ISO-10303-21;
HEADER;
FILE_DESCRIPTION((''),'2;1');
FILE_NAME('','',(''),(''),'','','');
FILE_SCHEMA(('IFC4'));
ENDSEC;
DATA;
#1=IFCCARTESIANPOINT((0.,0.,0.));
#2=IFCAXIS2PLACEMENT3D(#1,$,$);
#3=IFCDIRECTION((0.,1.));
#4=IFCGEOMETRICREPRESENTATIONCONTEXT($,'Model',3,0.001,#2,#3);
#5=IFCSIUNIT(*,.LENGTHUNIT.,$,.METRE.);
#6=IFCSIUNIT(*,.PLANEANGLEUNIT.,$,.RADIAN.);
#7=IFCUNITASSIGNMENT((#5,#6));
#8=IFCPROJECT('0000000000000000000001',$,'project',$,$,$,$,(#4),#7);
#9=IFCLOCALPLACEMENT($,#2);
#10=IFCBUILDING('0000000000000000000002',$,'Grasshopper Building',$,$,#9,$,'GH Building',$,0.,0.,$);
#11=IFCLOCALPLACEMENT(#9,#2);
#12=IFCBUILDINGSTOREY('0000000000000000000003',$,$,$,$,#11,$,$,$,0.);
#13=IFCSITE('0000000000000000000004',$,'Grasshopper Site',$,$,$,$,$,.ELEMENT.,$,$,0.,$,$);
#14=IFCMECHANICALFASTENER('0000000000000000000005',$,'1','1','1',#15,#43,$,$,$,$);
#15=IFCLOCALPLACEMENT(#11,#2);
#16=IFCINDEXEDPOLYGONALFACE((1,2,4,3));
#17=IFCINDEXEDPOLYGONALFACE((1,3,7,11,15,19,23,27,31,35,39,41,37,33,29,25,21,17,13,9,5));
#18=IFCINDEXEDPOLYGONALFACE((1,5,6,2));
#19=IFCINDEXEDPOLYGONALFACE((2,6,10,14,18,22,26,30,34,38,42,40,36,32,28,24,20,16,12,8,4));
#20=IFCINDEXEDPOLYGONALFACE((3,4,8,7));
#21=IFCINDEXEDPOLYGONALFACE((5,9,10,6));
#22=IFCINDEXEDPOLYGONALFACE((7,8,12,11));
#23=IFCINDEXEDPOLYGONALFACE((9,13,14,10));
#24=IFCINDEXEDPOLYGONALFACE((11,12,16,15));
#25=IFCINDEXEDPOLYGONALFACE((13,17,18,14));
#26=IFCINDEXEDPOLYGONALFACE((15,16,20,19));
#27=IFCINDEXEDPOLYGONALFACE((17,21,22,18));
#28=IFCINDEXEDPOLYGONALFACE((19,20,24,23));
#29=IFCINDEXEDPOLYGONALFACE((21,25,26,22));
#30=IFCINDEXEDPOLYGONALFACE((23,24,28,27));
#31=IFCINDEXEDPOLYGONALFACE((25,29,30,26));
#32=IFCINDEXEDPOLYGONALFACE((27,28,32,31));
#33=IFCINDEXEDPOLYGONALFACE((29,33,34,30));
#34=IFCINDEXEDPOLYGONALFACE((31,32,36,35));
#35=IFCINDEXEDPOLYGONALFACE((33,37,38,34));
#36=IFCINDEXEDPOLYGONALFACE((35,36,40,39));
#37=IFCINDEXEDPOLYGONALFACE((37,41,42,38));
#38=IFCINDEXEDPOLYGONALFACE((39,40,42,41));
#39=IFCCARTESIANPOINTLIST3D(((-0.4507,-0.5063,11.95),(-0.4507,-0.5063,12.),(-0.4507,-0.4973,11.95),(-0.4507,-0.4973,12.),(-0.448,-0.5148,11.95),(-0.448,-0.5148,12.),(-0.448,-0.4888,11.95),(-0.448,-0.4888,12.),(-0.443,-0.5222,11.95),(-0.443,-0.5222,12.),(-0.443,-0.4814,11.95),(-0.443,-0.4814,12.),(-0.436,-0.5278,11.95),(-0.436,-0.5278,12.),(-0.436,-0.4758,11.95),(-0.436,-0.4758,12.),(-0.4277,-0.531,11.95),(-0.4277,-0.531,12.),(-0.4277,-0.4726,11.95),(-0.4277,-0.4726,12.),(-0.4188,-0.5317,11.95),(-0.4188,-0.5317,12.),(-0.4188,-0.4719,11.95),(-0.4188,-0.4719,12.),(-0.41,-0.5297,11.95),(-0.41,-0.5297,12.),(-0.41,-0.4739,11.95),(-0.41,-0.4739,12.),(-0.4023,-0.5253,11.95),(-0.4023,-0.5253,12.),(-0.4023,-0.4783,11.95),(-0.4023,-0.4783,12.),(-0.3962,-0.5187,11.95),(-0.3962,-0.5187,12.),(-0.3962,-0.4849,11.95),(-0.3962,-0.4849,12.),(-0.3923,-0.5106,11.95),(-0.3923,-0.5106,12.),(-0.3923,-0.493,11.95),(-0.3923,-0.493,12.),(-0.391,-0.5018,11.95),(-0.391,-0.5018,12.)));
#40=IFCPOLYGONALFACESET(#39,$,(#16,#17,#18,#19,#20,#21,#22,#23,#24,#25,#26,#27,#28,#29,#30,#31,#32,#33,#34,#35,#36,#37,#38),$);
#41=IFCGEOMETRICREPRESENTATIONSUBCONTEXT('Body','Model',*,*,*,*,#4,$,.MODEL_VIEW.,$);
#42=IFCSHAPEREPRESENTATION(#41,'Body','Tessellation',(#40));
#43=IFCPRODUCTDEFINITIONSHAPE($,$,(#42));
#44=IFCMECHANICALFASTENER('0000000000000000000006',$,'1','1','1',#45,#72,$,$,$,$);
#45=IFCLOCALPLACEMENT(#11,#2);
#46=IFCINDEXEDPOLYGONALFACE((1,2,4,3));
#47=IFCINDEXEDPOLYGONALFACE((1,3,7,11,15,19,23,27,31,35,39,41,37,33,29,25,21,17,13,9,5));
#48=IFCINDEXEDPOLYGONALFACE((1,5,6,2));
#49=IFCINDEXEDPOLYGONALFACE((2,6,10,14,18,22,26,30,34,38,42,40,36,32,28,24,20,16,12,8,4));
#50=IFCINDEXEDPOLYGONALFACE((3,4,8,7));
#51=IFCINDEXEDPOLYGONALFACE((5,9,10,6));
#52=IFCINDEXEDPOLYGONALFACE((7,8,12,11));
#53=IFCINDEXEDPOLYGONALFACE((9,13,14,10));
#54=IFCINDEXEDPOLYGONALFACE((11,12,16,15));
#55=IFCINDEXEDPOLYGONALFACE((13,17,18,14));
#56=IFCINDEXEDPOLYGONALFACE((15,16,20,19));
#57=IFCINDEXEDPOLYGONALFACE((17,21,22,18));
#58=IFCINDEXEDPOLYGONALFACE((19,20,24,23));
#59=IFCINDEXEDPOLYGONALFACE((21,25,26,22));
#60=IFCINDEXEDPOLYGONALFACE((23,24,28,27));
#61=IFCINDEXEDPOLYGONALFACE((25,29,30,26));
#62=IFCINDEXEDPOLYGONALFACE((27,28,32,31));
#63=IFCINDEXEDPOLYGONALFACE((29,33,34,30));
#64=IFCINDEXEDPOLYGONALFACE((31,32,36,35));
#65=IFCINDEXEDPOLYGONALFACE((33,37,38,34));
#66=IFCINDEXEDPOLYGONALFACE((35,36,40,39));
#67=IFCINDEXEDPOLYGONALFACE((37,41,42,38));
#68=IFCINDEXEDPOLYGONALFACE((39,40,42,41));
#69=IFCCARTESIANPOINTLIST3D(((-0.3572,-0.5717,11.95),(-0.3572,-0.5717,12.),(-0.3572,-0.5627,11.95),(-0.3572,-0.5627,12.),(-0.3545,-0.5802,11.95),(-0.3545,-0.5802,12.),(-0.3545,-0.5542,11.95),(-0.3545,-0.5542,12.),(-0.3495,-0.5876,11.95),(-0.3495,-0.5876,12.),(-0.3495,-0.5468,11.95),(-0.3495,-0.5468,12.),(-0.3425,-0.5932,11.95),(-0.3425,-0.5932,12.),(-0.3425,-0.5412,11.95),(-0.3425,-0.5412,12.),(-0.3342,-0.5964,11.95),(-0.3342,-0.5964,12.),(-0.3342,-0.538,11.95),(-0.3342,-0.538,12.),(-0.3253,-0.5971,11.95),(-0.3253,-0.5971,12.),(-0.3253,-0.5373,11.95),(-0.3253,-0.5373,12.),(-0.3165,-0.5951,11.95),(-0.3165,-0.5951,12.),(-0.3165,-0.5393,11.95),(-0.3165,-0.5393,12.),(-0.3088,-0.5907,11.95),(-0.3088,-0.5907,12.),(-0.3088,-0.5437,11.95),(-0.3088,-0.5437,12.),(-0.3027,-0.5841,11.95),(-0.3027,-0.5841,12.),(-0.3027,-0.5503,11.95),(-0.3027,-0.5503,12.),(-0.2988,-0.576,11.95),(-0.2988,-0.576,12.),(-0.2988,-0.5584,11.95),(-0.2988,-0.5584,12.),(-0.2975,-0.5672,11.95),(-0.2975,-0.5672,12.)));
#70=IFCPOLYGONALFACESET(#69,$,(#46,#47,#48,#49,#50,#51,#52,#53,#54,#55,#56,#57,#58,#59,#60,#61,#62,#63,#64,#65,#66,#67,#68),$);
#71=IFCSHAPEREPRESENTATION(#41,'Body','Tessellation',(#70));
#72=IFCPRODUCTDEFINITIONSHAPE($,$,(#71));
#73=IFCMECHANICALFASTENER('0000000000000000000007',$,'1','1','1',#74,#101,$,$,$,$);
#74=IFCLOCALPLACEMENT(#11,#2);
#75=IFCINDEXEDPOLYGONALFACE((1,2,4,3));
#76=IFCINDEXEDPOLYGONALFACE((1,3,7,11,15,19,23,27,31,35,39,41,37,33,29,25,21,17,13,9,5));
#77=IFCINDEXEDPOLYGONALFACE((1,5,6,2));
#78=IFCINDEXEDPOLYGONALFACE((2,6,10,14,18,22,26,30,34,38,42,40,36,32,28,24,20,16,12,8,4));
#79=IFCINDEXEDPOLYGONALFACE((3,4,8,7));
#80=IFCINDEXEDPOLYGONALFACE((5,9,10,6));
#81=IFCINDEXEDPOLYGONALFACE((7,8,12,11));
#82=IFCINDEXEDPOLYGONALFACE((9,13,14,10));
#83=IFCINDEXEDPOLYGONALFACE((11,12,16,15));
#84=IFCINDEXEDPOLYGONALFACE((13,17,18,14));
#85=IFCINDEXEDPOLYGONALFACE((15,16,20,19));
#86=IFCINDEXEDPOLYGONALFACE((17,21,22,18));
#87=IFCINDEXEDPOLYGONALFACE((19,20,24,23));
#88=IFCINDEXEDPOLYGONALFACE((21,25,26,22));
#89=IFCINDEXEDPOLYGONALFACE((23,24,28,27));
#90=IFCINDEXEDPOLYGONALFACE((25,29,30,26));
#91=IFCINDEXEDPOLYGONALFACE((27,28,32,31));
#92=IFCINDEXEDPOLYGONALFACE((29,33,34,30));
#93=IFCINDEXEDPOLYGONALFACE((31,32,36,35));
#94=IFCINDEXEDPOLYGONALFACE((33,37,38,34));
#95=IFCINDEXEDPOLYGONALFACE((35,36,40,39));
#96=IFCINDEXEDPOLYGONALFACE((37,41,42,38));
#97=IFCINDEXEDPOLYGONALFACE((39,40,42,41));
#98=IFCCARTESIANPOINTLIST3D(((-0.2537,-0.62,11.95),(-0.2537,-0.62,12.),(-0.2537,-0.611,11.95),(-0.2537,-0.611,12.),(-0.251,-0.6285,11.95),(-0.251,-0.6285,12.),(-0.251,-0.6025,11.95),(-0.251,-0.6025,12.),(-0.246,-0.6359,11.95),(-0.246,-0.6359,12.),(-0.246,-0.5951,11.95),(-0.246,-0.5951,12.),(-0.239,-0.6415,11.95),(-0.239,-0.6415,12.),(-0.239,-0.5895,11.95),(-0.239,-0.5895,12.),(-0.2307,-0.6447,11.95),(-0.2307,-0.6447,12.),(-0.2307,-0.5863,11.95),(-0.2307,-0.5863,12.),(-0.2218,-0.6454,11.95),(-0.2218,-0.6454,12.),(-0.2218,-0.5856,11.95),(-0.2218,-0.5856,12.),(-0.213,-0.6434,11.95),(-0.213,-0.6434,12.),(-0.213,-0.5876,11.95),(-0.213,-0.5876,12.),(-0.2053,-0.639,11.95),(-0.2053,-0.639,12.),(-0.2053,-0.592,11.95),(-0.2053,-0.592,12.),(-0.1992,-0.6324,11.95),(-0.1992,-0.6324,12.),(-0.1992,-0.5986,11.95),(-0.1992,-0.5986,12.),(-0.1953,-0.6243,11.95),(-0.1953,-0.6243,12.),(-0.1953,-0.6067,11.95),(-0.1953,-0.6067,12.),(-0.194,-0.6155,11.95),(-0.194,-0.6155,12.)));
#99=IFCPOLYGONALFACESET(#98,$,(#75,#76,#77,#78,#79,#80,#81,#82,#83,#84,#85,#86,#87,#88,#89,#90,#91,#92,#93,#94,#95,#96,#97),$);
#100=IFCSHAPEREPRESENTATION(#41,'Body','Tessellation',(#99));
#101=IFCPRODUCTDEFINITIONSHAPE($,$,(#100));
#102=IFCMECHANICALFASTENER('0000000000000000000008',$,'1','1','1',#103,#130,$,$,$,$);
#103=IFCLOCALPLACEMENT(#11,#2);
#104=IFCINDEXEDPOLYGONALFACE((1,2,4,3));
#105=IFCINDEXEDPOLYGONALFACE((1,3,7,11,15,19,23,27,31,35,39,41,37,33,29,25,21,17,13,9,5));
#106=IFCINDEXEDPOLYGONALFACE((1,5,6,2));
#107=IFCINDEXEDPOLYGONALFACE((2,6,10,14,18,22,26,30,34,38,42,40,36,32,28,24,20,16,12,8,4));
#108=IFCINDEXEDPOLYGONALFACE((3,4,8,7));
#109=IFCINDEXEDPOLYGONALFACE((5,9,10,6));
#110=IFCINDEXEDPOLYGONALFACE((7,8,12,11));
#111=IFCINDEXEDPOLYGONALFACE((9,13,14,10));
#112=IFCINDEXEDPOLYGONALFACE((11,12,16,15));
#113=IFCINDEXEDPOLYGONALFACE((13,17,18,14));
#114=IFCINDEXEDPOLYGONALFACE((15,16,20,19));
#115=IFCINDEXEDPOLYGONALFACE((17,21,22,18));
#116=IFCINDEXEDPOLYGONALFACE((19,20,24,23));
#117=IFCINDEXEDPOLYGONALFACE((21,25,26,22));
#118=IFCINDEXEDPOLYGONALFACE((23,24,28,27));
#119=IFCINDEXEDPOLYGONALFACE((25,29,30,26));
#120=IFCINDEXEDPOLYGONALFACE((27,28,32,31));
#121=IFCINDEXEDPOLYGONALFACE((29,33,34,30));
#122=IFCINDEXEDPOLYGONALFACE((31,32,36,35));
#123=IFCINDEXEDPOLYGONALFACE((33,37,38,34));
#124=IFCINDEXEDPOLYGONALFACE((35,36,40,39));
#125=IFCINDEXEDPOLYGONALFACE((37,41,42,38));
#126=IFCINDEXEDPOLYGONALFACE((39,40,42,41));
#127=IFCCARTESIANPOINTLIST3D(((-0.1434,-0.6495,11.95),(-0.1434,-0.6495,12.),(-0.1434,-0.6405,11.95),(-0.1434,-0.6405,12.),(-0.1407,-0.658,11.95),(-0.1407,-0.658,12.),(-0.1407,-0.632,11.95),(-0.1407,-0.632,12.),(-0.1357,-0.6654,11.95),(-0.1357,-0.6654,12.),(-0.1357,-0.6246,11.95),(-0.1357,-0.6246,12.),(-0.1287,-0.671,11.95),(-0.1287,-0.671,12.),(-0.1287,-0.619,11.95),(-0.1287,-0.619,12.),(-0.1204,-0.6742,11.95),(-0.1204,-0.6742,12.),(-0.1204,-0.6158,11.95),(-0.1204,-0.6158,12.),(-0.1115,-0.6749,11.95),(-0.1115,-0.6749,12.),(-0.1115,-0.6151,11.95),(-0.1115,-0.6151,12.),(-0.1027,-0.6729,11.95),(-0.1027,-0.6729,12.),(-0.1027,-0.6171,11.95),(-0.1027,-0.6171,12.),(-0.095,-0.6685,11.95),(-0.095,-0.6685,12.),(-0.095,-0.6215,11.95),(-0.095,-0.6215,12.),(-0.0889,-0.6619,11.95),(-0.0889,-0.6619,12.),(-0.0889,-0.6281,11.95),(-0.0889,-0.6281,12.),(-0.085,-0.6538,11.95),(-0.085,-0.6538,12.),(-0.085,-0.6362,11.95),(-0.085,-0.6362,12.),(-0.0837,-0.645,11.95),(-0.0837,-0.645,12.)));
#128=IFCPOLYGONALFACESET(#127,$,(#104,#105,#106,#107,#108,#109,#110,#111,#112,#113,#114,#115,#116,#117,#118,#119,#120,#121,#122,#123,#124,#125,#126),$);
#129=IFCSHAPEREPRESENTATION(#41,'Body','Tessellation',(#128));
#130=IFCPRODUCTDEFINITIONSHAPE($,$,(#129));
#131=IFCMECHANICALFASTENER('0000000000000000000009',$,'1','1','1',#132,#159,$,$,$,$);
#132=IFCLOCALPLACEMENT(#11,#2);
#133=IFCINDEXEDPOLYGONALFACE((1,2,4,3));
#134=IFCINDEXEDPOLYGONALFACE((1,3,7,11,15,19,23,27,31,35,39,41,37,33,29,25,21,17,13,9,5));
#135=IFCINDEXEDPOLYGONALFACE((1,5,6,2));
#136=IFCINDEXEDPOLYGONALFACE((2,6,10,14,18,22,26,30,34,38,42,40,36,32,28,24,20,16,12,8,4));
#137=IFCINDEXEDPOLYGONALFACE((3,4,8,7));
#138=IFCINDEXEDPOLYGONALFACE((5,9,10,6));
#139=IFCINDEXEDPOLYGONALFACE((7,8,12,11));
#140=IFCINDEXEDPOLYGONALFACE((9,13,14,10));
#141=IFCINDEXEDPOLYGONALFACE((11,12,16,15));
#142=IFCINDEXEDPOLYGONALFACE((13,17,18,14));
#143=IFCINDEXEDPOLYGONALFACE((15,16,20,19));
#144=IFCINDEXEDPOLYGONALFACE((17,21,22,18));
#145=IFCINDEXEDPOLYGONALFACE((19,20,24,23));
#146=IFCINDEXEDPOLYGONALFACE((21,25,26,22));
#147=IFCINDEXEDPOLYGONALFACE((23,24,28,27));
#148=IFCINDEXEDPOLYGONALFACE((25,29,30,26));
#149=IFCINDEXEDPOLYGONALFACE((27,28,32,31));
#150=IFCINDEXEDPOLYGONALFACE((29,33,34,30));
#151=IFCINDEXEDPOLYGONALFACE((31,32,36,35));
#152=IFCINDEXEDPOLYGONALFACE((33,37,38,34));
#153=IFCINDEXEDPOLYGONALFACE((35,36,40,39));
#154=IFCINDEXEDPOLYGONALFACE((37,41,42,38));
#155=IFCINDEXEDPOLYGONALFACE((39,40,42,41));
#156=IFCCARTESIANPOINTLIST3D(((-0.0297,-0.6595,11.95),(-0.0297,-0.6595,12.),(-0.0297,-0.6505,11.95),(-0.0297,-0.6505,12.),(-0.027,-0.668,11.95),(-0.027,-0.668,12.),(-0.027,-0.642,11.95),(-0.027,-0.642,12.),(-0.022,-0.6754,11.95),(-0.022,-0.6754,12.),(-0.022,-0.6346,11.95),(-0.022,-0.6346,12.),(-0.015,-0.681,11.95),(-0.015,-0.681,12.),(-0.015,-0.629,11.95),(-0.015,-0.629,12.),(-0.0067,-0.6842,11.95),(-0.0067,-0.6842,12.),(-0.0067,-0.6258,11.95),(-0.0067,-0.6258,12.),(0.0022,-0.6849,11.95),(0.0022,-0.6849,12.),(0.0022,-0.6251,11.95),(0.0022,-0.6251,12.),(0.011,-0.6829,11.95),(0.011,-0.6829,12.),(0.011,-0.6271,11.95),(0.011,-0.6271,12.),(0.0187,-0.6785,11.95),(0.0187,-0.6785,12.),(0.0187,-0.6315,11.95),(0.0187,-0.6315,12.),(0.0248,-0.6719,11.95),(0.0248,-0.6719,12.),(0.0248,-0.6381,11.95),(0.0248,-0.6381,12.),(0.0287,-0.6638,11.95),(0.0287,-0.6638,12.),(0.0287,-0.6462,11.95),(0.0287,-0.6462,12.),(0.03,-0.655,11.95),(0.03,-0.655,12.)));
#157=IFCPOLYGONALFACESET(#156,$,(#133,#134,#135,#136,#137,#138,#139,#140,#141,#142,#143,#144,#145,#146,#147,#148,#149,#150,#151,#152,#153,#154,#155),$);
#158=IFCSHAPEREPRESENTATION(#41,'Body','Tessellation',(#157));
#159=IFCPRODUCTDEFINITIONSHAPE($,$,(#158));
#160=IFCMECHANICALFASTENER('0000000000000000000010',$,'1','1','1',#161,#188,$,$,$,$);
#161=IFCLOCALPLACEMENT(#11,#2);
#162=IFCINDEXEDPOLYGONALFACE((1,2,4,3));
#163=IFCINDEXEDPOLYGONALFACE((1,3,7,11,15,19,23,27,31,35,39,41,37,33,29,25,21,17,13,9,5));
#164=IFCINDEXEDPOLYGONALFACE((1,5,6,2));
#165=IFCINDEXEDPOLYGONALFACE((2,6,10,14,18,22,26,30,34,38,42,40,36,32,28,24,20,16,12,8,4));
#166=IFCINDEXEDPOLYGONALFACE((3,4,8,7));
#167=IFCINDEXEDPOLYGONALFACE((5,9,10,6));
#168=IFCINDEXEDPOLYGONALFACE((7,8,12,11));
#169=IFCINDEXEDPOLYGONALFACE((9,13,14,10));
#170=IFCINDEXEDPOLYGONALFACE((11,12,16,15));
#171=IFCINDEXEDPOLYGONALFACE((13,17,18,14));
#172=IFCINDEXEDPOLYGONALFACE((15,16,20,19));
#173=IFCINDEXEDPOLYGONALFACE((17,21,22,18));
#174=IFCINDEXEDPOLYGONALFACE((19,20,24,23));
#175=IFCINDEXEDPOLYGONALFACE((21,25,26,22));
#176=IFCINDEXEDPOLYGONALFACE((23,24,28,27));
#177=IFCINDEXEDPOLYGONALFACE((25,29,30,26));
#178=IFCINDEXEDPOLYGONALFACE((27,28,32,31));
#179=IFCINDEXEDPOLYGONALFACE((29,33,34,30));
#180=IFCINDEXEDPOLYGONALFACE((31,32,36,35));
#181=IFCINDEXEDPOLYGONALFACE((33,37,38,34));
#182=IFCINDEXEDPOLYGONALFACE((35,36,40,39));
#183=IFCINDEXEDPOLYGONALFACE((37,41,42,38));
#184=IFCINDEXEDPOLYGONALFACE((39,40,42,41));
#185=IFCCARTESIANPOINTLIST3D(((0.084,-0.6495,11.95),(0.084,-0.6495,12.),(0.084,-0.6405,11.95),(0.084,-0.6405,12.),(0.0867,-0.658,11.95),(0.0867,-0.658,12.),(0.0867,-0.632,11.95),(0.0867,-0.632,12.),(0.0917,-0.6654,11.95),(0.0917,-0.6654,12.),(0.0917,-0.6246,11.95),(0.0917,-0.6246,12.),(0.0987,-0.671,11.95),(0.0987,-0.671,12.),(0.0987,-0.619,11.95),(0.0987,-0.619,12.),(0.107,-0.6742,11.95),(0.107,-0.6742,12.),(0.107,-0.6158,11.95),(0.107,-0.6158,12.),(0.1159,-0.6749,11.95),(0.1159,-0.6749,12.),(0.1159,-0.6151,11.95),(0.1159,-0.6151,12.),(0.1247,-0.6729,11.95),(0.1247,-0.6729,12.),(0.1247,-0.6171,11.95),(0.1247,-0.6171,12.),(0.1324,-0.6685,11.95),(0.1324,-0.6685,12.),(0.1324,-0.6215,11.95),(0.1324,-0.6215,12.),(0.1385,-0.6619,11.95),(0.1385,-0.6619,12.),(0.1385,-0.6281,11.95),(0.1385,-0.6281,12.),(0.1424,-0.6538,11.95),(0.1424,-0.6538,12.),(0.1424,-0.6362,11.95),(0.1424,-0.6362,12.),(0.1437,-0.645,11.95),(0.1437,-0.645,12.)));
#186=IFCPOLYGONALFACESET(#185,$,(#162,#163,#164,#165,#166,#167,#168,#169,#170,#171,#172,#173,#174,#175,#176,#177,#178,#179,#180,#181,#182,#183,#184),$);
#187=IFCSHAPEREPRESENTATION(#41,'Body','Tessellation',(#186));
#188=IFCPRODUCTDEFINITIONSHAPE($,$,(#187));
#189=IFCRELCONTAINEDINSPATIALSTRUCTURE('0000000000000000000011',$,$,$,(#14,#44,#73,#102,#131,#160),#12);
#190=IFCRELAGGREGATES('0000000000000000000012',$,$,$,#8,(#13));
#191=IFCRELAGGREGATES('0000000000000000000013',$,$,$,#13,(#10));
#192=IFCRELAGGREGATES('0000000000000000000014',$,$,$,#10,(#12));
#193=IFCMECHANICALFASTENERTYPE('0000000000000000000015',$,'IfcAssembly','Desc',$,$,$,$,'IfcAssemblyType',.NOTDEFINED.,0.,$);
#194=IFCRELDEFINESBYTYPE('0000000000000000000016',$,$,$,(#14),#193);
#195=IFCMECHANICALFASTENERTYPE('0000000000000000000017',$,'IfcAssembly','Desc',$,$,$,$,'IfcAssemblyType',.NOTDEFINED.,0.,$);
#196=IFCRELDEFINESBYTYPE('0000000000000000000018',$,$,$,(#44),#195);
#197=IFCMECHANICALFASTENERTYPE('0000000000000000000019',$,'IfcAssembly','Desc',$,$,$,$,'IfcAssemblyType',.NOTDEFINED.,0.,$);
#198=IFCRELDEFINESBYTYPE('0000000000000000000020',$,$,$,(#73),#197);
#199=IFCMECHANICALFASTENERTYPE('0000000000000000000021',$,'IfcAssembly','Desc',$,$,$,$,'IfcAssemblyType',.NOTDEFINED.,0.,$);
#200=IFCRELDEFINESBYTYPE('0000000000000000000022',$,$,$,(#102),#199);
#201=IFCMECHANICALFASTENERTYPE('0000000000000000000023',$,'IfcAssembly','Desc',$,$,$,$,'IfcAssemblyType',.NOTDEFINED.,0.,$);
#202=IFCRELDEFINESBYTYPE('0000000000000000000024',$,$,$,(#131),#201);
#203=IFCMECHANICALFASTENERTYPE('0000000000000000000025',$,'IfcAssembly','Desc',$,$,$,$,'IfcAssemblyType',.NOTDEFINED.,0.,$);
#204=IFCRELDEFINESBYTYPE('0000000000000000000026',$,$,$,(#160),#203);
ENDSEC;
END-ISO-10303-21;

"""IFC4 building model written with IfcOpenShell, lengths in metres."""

from ifc_helpers import new_model, si_unit, direction, frame, origin, place, context, subcontext, project, spatial, circle, extrude, source, transform, mapped, type_object, type_shapes, element, save


model = new_model("IFC4")

# Units and contexts
model_context = context("Model", 3, precision=0.001, world=origin(), true_north=direction((0.0, 1.0)))
body_context = subcontext(model_context, "Body", "Model", "MODEL_VIEW")
ifc_project = project(units=[si_unit("LENGTHUNIT", "METRE"), si_unit("PLANEANGLEUNIT", "RADIAN")], contexts=[model_context])

# Site, building, storey
site = spatial("IfcSite", under=ifc_project, Name="Grasshopper Site", CompositionType="ELEMENT", RefElevation=0.0)
building_placement = place(None, origin())
building = spatial("IfcBuilding", under=site, at=building_placement, Name="Grasshopper Building", LongName="GH Building", ElevationOfRefHeight=0.0, ElevationOfTerrain=0.0)
storey_placement = place(building_placement, origin())
storey = spatial("IfcBuildingStorey", under=building, at=storey_placement, Elevation=0.0)

# Mechanical fasteners
mechanical_fastener_type_1 = type_object("IfcMechanicalFastenerType", Name="IfcAssembly", Description="Desc", ElementType="IfcAssemblyType", NominalDiameter=0.0)
shared_shape_1 = source(origin(), body_context, "Body", "SweptSolid", [
    extrude(circle(Radius=0.03), frame((-0.421, -0.5018, 12.0), z_axis=(0.0, 0.0, -1.0), x_axis=(1.0, 0.0, 0.0)), (0.0, 0.0, 1.0), 0.05),
])
type_shapes(mechanical_fastener_type_1, [shared_shape_1])
mechanical_fastener_1_placement = place(storey_placement, origin())
element("IfcMechanicalFastener", 1, at=mechanical_fastener_1_placement, inside=storey, type_object=mechanical_fastener_type_1, Name="1", Description="1", ObjectType="1", context=body_context, shape_type="MappedRepresentation", body=[
    mapped(shared_shape_1, transform((0.0, 0.0, 0.0), scale=1.0)),
])
mechanical_fastener_type_2 = type_object("IfcMechanicalFastenerType", Name="IfcAssembly", Description="Desc", ElementType="IfcAssemblyType", NominalDiameter=0.0)
shared_shape_2 = source(origin(), body_context, "Body", "SweptSolid", [
    extrude(circle(Radius=0.03), frame((-0.3275, -0.5672, 12.0), z_axis=(0.0, 0.0, -1.0), x_axis=(1.0, 0.0, 0.0)), (0.0, 0.0, 1.0), 0.05),
])
type_shapes(mechanical_fastener_type_2, [shared_shape_2])
mechanical_fastener_2_placement = place(storey_placement, origin())
element("IfcMechanicalFastener", 2, at=mechanical_fastener_2_placement, inside=storey, type_object=mechanical_fastener_type_2, Name="1", Description="1", ObjectType="1", context=body_context, shape_type="MappedRepresentation", body=[
    mapped(shared_shape_2, transform((0.0, 0.0, 0.0), scale=1.0)),
])
mechanical_fastener_type_3 = type_object("IfcMechanicalFastenerType", Name="IfcAssembly", Description="Desc", ElementType="IfcAssemblyType", NominalDiameter=0.0)
shared_shape_3 = source(origin(), body_context, "Body", "SweptSolid", [
    extrude(circle(Radius=0.03), frame((-0.224, -0.6155, 12.0), z_axis=(0.0, 0.0, -1.0), x_axis=(1.0, 0.0, 0.0)), (0.0, 0.0, 1.0), 0.05),
])
type_shapes(mechanical_fastener_type_3, [shared_shape_3])
mechanical_fastener_3_placement = place(storey_placement, origin())
element("IfcMechanicalFastener", 3, at=mechanical_fastener_3_placement, inside=storey, type_object=mechanical_fastener_type_3, Name="1", Description="1", ObjectType="1", context=body_context, shape_type="MappedRepresentation", body=[
    mapped(shared_shape_3, transform((0.0, 0.0, 0.0), scale=1.0)),
])
mechanical_fastener_type_4 = type_object("IfcMechanicalFastenerType", Name="IfcAssembly", Description="Desc", ElementType="IfcAssemblyType", NominalDiameter=0.0)
shared_shape_4 = source(origin(), body_context, "Body", "SweptSolid", [
    extrude(circle(Radius=0.03), frame((-0.1137, -0.645, 12.0), z_axis=(0.0, 0.0, -1.0), x_axis=(1.0, 0.0, 0.0)), (0.0, 0.0, 1.0), 0.05),
])
type_shapes(mechanical_fastener_type_4, [shared_shape_4])
mechanical_fastener_4_placement = place(storey_placement, origin())
element("IfcMechanicalFastener", 4, at=mechanical_fastener_4_placement, inside=storey, type_object=mechanical_fastener_type_4, Name="1", Description="1", ObjectType="1", context=body_context, shape_type="MappedRepresentation", body=[
    mapped(shared_shape_4, transform((0.0, 0.0, 0.0), scale=1.0)),
])
mechanical_fastener_type_5 = type_object("IfcMechanicalFastenerType", Name="IfcAssembly", Description="Desc", ElementType="IfcAssemblyType", NominalDiameter=0.0)
shared_shape_5 = source(origin(), body_context, "Body", "SweptSolid", [
    extrude(circle(Radius=0.03), frame((0.0, -0.655, 12.0), z_axis=(0.0, 0.0, -1.0), x_axis=(1.0, 0.0, 0.0)), (0.0, 0.0, 1.0), 0.05),
])
type_shapes(mechanical_fastener_type_5, [shared_shape_5])
mechanical_fastener_5_placement = place(storey_placement, origin())
element("IfcMechanicalFastener", 5, at=mechanical_fastener_5_placement, inside=storey, type_object=mechanical_fastener_type_5, Name="1", Description="1", ObjectType="1", context=body_context, shape_type="MappedRepresentation", body=[
    mapped(shared_shape_5, transform((0.0, 0.0, 0.0), scale=1.0)),
])
mechanical_fastener_type_6 = type_object("IfcMechanicalFastenerType", Name="IfcAssembly", Description="Desc", ElementType="IfcAssemblyType", NominalDiameter=0.0)
shared_shape_6 = source(origin(), body_context, "Body", "SweptSolid", [
    extrude(circle(Radius=0.03), frame((0.1137, -0.645, 12.0), z_axis=(0.0, 0.0, -1.0), x_axis=(1.0, 0.0, 0.0)), (0.0, 0.0, 1.0), 0.05),
])
type_shapes(mechanical_fastener_type_6, [shared_shape_6])
mechanical_fastener_6_placement = place(storey_placement, origin())
element("IfcMechanicalFastener", 6, at=mechanical_fastener_6_placement, inside=storey, type_object=mechanical_fastener_type_6, Name="1", Description="1", ObjectType="1", context=body_context, shape_type="MappedRepresentation", body=[
    mapped(shared_shape_6, transform((0.0, 0.0, 0.0), scale=1.0)),
])

save(model, "model.ifc")
